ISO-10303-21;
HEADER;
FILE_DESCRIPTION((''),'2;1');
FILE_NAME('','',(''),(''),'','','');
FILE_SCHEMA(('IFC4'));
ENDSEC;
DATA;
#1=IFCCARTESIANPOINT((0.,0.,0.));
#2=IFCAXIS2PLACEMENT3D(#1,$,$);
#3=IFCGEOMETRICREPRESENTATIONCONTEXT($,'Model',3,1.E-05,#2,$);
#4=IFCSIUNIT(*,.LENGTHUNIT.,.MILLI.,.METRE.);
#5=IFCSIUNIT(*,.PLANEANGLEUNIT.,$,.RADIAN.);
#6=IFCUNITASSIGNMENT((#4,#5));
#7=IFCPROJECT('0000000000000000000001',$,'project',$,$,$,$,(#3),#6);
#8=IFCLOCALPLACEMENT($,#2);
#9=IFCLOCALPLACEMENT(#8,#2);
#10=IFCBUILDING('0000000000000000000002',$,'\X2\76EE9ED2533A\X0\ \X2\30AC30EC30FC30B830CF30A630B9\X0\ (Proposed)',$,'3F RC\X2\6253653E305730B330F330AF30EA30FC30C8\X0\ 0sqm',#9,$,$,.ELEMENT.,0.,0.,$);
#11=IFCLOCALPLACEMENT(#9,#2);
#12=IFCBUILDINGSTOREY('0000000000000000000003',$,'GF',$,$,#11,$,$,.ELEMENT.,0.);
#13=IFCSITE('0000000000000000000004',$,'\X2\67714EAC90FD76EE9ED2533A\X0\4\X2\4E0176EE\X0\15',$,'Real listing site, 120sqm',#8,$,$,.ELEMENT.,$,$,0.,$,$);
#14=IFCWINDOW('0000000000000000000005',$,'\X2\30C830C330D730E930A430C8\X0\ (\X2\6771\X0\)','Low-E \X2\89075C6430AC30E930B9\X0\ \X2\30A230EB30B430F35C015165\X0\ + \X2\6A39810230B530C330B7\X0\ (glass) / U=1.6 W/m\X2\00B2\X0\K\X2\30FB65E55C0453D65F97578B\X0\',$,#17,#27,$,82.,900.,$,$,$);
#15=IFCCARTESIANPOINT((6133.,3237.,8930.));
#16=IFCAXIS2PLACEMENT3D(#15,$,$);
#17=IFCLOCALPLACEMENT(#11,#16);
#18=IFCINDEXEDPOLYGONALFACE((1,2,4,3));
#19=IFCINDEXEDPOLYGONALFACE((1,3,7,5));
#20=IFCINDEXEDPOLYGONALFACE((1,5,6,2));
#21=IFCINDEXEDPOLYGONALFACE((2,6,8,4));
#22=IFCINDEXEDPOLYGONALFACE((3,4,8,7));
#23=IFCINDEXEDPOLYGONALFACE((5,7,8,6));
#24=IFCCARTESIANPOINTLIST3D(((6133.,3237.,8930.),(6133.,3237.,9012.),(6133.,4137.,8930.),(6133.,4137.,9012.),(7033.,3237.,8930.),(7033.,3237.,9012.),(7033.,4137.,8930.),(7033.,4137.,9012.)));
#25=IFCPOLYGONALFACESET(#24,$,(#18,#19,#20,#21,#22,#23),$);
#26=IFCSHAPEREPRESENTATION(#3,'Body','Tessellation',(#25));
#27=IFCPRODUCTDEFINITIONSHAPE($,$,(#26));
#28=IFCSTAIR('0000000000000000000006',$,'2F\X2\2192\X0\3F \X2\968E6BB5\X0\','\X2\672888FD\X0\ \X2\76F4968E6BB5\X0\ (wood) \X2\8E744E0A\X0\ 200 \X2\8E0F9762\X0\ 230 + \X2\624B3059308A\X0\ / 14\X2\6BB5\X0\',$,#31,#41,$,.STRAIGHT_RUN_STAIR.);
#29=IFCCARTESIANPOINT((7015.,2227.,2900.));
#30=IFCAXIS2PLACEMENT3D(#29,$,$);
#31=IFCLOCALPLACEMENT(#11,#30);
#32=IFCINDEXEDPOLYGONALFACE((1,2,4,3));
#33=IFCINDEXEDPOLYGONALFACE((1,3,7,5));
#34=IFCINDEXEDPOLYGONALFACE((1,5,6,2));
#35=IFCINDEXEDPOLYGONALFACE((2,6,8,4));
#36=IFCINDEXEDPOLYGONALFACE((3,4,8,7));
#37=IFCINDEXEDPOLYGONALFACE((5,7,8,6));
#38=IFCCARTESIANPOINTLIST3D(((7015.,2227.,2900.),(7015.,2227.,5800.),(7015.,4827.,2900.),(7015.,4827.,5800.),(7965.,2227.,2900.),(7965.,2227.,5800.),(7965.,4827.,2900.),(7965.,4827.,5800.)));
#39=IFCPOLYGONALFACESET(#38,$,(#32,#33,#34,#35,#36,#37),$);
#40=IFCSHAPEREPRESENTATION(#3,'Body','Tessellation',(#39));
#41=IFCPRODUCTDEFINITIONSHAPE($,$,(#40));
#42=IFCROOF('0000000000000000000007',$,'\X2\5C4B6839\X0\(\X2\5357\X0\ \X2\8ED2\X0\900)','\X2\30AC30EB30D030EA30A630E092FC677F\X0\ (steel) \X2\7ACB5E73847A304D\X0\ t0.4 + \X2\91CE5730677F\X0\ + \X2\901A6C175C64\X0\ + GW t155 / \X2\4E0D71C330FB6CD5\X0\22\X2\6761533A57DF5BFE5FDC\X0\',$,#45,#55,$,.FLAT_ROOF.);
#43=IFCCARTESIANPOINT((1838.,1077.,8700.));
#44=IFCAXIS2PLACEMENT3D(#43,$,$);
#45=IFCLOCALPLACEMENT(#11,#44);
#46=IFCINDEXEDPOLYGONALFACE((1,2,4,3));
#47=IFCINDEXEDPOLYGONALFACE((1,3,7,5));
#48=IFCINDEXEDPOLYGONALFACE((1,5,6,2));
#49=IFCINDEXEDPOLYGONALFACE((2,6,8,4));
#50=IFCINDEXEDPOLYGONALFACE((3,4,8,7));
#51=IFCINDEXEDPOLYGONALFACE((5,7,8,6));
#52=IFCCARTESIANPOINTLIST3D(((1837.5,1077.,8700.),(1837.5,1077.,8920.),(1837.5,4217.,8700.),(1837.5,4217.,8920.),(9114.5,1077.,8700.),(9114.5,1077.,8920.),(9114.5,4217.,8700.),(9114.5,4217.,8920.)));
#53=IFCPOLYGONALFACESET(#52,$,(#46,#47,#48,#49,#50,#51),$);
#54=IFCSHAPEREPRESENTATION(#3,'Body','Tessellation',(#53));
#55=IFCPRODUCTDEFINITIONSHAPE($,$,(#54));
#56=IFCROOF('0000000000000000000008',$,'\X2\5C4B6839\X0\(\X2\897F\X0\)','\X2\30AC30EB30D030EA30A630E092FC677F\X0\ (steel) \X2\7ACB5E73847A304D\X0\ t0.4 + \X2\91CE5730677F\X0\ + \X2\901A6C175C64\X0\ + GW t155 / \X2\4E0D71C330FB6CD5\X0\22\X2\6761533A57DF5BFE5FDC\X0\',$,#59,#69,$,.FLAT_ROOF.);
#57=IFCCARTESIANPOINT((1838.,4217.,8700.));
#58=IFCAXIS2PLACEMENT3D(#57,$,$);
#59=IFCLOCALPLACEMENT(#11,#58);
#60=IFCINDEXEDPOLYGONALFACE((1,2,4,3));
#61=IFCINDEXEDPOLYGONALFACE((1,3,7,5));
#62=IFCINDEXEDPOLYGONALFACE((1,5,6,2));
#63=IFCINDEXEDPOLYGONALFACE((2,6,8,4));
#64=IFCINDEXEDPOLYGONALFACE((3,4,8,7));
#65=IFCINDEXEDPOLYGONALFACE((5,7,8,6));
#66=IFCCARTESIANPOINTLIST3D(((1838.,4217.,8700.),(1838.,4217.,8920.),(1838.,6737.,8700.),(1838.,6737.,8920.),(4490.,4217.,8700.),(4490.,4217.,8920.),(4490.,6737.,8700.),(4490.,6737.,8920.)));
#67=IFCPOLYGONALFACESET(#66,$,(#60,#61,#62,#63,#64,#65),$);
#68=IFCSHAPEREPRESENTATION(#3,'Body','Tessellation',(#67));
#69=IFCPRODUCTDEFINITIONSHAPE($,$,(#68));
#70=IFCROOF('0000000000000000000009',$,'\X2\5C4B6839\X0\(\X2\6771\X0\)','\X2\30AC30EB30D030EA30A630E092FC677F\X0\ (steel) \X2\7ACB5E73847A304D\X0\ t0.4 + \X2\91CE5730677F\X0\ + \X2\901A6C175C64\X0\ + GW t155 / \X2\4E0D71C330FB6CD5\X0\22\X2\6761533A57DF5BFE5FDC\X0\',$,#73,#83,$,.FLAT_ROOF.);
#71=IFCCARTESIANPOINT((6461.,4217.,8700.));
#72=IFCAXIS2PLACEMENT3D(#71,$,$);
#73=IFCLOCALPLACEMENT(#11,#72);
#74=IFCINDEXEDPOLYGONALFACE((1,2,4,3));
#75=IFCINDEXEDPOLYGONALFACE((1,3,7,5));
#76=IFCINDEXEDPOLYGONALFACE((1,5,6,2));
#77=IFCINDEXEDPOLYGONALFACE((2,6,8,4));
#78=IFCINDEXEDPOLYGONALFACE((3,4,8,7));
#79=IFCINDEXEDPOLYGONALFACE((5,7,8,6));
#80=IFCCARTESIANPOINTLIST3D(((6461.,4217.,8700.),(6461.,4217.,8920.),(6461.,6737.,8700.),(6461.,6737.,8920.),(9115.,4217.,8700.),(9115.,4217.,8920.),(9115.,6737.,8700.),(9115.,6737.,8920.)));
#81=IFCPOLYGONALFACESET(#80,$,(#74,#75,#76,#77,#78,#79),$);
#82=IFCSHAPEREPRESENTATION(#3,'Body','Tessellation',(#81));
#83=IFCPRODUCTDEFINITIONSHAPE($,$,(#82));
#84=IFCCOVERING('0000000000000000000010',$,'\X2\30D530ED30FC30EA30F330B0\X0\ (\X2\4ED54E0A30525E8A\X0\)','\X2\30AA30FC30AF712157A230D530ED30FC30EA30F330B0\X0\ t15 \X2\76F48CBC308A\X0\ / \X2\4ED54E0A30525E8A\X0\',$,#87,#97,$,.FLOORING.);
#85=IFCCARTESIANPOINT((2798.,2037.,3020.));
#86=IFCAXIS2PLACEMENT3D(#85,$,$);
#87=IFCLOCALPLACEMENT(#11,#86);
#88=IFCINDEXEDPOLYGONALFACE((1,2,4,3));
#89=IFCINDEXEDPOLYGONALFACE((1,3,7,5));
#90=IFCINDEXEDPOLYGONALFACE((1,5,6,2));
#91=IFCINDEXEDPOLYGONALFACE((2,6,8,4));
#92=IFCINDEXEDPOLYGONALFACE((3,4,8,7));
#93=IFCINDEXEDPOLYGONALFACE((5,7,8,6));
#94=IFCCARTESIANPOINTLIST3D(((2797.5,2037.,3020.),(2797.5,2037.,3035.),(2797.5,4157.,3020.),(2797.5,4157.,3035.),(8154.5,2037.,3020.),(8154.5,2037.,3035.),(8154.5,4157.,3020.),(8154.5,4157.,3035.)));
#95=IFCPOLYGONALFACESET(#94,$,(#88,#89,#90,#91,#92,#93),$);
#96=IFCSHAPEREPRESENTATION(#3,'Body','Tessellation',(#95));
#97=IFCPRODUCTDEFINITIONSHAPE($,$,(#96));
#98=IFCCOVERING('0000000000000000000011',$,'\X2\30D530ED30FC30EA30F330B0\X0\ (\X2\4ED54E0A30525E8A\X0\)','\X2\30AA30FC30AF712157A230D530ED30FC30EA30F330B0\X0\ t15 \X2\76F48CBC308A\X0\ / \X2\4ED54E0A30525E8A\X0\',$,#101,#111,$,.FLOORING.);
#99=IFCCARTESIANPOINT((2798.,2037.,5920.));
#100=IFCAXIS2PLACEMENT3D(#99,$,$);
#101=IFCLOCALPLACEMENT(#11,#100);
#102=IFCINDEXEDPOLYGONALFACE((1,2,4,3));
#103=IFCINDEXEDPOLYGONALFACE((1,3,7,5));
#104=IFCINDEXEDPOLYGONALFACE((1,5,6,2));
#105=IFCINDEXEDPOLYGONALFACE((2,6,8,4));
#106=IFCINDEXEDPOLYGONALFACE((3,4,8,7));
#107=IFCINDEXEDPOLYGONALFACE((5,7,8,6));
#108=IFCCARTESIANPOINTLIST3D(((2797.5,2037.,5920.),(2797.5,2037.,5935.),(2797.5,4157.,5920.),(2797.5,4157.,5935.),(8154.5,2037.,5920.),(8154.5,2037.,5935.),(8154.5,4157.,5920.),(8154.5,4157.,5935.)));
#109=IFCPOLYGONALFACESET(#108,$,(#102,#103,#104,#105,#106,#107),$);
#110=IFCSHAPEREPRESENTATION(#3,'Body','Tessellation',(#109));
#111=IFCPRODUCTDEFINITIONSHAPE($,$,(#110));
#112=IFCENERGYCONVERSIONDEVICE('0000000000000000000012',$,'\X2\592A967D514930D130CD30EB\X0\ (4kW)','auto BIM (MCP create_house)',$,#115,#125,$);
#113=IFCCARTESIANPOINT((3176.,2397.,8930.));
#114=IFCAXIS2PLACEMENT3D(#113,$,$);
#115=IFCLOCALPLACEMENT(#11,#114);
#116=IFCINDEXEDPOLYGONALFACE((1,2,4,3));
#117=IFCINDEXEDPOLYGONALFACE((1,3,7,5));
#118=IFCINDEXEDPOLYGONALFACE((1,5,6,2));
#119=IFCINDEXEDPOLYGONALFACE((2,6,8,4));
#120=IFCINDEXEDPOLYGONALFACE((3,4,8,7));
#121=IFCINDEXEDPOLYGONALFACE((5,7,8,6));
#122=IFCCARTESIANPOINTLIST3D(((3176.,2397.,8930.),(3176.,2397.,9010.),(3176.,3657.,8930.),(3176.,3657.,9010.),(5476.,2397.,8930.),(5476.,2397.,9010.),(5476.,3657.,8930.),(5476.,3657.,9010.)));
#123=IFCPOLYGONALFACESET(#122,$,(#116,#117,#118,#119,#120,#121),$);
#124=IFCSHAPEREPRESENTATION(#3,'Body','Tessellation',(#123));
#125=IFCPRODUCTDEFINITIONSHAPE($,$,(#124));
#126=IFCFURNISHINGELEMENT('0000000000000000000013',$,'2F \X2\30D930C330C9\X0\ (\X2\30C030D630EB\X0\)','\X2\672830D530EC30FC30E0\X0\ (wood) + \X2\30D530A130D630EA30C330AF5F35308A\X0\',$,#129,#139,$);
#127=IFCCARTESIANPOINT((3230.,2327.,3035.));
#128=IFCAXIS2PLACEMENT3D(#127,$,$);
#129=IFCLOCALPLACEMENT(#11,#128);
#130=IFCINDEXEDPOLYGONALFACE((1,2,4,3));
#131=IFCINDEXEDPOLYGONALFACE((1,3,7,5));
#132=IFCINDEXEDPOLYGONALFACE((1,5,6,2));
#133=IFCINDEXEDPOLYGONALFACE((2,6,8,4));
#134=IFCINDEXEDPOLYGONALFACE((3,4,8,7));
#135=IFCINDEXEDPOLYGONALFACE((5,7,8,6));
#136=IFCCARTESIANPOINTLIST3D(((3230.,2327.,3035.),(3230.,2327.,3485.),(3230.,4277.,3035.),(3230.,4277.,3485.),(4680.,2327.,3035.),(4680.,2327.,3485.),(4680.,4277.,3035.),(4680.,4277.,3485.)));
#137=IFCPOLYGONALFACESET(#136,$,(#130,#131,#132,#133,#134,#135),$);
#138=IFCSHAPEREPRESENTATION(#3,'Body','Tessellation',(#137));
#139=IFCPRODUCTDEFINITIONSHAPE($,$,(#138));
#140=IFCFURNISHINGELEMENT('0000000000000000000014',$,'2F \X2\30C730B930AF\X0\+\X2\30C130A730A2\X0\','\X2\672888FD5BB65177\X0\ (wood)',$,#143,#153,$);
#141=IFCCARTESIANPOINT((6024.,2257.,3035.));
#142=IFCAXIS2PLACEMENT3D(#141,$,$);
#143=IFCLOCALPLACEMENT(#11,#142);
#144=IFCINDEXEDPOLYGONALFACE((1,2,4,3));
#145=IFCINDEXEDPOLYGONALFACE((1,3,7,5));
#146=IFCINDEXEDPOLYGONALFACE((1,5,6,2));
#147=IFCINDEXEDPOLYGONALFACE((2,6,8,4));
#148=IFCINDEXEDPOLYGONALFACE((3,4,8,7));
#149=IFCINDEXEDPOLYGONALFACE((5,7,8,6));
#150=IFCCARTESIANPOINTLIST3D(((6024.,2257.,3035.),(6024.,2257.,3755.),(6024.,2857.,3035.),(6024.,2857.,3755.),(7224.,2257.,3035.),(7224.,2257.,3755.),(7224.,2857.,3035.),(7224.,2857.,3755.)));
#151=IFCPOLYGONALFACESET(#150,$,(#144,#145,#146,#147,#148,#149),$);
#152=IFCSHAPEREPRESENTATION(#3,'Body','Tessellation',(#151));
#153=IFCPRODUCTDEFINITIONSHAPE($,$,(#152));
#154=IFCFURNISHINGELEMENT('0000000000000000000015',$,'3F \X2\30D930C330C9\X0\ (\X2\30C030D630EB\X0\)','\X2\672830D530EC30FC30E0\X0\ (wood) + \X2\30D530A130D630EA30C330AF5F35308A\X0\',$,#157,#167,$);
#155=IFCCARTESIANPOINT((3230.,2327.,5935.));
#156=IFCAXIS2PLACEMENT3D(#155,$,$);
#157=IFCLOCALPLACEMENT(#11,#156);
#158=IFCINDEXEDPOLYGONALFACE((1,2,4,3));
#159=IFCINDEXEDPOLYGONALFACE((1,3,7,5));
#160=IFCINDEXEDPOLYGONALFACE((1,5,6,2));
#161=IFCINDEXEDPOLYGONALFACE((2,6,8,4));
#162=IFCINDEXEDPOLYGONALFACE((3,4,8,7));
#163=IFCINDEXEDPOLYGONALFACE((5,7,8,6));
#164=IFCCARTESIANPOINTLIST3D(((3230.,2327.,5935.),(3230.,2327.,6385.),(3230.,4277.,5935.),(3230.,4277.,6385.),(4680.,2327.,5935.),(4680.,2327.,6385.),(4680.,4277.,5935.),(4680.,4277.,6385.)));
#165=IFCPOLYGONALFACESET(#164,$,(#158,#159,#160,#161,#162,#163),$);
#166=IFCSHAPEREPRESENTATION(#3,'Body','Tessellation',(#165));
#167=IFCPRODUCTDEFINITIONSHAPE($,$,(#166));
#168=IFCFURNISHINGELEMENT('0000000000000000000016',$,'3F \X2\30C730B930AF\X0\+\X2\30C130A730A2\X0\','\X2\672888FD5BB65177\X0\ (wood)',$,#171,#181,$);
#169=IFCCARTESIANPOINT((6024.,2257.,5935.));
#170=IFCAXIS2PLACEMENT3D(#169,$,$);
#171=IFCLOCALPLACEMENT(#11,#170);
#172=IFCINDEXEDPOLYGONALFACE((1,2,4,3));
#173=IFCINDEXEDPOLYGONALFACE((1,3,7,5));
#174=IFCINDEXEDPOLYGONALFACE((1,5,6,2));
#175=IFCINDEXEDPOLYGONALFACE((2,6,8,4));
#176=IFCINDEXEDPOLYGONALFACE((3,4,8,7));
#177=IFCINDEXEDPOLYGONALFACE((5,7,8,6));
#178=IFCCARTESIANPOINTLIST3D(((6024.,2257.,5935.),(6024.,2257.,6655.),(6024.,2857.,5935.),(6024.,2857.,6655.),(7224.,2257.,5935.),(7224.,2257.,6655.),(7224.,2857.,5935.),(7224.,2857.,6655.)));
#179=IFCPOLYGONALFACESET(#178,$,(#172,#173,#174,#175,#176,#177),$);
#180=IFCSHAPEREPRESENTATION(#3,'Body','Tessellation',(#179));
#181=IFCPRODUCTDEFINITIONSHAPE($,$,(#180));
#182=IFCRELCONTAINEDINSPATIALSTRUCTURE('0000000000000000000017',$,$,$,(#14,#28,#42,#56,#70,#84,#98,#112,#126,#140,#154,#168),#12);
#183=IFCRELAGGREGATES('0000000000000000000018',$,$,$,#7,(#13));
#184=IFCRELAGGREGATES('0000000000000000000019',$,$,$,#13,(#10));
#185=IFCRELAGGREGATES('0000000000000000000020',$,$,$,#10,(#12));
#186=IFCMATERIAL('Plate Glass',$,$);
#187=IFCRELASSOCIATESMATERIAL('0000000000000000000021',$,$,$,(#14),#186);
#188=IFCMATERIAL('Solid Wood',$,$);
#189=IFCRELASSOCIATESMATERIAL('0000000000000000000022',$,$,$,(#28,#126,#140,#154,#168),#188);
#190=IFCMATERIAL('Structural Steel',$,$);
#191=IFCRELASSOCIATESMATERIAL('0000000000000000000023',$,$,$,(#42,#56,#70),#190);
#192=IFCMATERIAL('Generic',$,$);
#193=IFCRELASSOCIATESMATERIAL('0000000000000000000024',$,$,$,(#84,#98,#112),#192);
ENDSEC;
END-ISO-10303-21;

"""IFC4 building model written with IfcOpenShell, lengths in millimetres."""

from ifc_helpers import new_model, si_unit, frame, frame_2d, origin, place, context, project, spatial, rectangle, extrude, material, element, save


model = new_model("IFC4")

# Units and contexts
model_context = context("Model", 3, precision=1e-05, world=origin())
ifc_project = project(units=[si_unit("LENGTHUNIT", "METRE", prefix="MILLI"), si_unit("PLANEANGLEUNIT", "RADIAN")], contexts=[model_context])

# Site, building, storey
site_placement = place(None, origin())
site = spatial("IfcSite", under=ifc_project, at=site_placement, Name="東京都目黒区4丁目15", ObjectType="Real listing site, 120sqm", CompositionType="ELEMENT", RefElevation=0.0)
building_placement = place(site_placement, origin())
building = spatial("IfcBuilding", under=site, at=building_placement, Name="目黒区 ガレージハウス (Proposed)", ObjectType="3F RC打放しコンクリート 0sqm", CompositionType="ELEMENT", ElevationOfRefHeight=0.0, ElevationOfTerrain=0.0)
storey_placement = place(building_placement, origin())
storey = spatial("IfcBuildingStorey", under=building, at=storey_placement, Name="GF", CompositionType="ELEMENT", Elevation=0.0)

# Shared definitions
ifc_material_1 = material(Name="Solid Wood")

# Shared definitions
ifc_material_2 = material(Name="Plate Glass")

# Window
window_1_placement = place(storey_placement, frame((6133.0, 3237.0, 8930.0)))
element("IfcWindow", 1, at=window_1_placement, inside=storey, material=ifc_material_2, Name="トップライト (東)", Description="Low-E 複層ガラス アルゴン封入 + 樹脂サッシ (glass) / U=1.6 W/m²K・日射取得型", OverallHeight=82.0, OverallWidth=900.0, context=model_context, shape_type="SweptSolid", body=[
    extrude(rectangle(XDim=900.0, YDim=900.0, at=frame_2d((450.0, 450.0))), frame((6133.0, 3237.0, 8930.0)), (0.0, 0.0, 1.0), 82.0),
])

# Stair
stair_placement = place(storey_placement, frame((7015.0, 2227.0, 2900.0)))
element("IfcStair", 2, at=stair_placement, inside=storey, material=ifc_material_1, Name="2F→3F 階段", Description="木製 直階段 (wood) 蹴上 200 踏面 230 + 手すり / 14段", PredefinedType="STRAIGHT_RUN_STAIR", context=model_context, shape_type="SweptSolid", body=[
    extrude(rectangle(XDim=950.0, YDim=2600.0, at=frame_2d((475.0, 1300.0))), frame((7015.0, 2227.0, 2900.0)), (0.0, 0.0, 1.0), 2900.0),
])

# Roofs
ifc_material_3 = material(Name="Structural Steel")
roof_1_placement = place(storey_placement, frame((1838.0, 1077.0, 8700.0)))
element("IfcRoof", 3, at=roof_1_placement, inside=storey, material=ifc_material_3, Name="屋根(南 軒900)", Description="ガルバリウム鋼板 (steel) 立平葺き t0.4 + 野地板 + 通気層 + GW t155 / 不燃・法22条区域対応", PredefinedType="FLAT_ROOF", context=model_context, shape_type="SweptSolid", body=[
    extrude(rectangle(XDim=7277.0, YDim=3140.0, at=frame_2d((3638.0, 1570.0))), frame((1838.0, 1077.0, 8700.0)), (0.0, 0.0, 1.0), 220.0),
])
roof_2_placement = place(storey_placement, frame((1838.0, 4217.0, 8700.0)))
element("IfcRoof", 4, at=roof_2_placement, inside=storey, material=ifc_material_3, Name="屋根(西)", Description="ガルバリウム鋼板 (steel) 立平葺き t0.4 + 野地板 + 通気層 + GW t155 / 不燃・法22条区域対応", PredefinedType="FLAT_ROOF", context=model_context, shape_type="SweptSolid", body=[
    extrude(rectangle(XDim=2652.0, YDim=2520.0, at=frame_2d((1326.0, 1260.0))), frame((1838.0, 4217.0, 8700.0)), (0.0, 0.0, 1.0), 220.0),
])
roof_3_placement = place(storey_placement, frame((6461.0, 4217.0, 8700.0)))
element("IfcRoof", 5, at=roof_3_placement, inside=storey, material=ifc_material_3, Name="屋根(東)", Description="ガルバリウム鋼板 (steel) 立平葺き t0.4 + 野地板 + 通気層 + GW t155 / 不燃・法22条区域対応", PredefinedType="FLAT_ROOF", context=model_context, shape_type="SweptSolid", body=[
    extrude(rectangle(XDim=2654.0, YDim=2520.0, at=frame_2d((1327.0, 1260.0))), frame((6461.0, 4217.0, 8700.0)), (0.0, 0.0, 1.0), 220.0),
])

# Coverings
ifc_material_4 = material(Name="Generic")
covering_1_placement = place(storey_placement, frame((2798.0, 2037.0, 3020.0)))
element("IfcCovering", 6, at=covering_1_placement, inside=storey, material=ifc_material_4, Name="フローリング (仕上げ床)", Description="オーク無垢フローリング t15 直貼り / 仕上げ床", PredefinedType="FLOORING", context=model_context, shape_type="SweptSolid", body=[
    extrude(rectangle(XDim=5357.0, YDim=2120.0, at=frame_2d((2678.0, 1060.0))), frame((2798.0, 2037.0, 3020.0)), (0.0, 0.0, 1.0), 15.0),
])
covering_2_placement = place(storey_placement, frame((2798.0, 2037.0, 5920.0)))
element("IfcCovering", 7, at=covering_2_placement, inside=storey, material=ifc_material_4, Name="フローリング (仕上げ床)", Description="オーク無垢フローリング t15 直貼り / 仕上げ床", PredefinedType="FLOORING", context=model_context, shape_type="SweptSolid", body=[
    extrude(rectangle(XDim=5357.0, YDim=2120.0, at=frame_2d((2678.0, 1060.0))), frame((2798.0, 2037.0, 5920.0)), (0.0, 0.0, 1.0), 15.0),
])

# Energy conversion device
energy_conversion_device_placement = place(storey_placement, frame((3176.0, 2397.0, 8930.0)))
element("IfcEnergyConversionDevice", 8, at=energy_conversion_device_placement, inside=storey, material=ifc_material_4, Name="太陽光パネル (4kW)", Description="auto BIM (MCP create_house)", context=model_context, shape_type="SweptSolid", body=[
    extrude(rectangle(XDim=2300.0, YDim=1260.0, at=frame_2d((1150.0, 630.0))), frame((3176.0, 2397.0, 8930.0)), (0.0, 0.0, 1.0), 80.0),
])

# Furnishing elements
furnishing_1_placement = place(storey_placement, frame((3230.0, 2327.0, 3035.0)))
element("IfcFurnishingElement", 9, at=furnishing_1_placement, inside=storey, material=ifc_material_1, Name="2F ベッド (ダブル)", Description="木フレーム (wood) + ファブリック張り", context=model_context, shape_type="SweptSolid", body=[
    extrude(rectangle(XDim=1450.0, YDim=1950.0, at=frame_2d((725.0, 975.0))), frame((3230.0, 2327.0, 3035.0)), (0.0, 0.0, 1.0), 450.0),
])
furnishing_2_placement = place(storey_placement, frame((6024.0, 2257.0, 3035.0)))
element("IfcFurnishingElement", 10, at=furnishing_2_placement, inside=storey, material=ifc_material_1, Name="2F デスク+チェア", Description="木製家具 (wood)", context=model_context, shape_type="SweptSolid", body=[
    extrude(rectangle(XDim=1200.0, YDim=600.0, at=frame_2d((600.0, 300.0))), frame((6024.0, 2257.0, 3035.0)), (0.0, 0.0, 1.0), 720.0),
])
furnishing_3_placement = place(storey_placement, frame((3230.0, 2327.0, 5935.0)))
element("IfcFurnishingElement", 11, at=furnishing_3_placement, inside=storey, material=ifc_material_1, Name="3F ベッド (ダブル)", Description="木フレーム (wood) + ファブリック張り", context=model_context, shape_type="SweptSolid", body=[
    extrude(rectangle(XDim=1450.0, YDim=1950.0, at=frame_2d((725.0, 975.0))), frame((3230.0, 2327.0, 5935.0)), (0.0, 0.0, 1.0), 450.0),
])
furnishing_4_placement = place(storey_placement, frame((6024.0, 2257.0, 5935.0)))
element("IfcFurnishingElement", 12, at=furnishing_4_placement, inside=storey, material=ifc_material_1, Name="3F デスク+チェア", Description="木製家具 (wood)", context=model_context, shape_type="SweptSolid", body=[
    extrude(rectangle(XDim=1200.0, YDim=600.0, at=frame_2d((600.0, 300.0))), frame((6024.0, 2257.0, 5935.0)), (0.0, 0.0, 1.0), 720.0),
])

save(model, "model.ifc")
